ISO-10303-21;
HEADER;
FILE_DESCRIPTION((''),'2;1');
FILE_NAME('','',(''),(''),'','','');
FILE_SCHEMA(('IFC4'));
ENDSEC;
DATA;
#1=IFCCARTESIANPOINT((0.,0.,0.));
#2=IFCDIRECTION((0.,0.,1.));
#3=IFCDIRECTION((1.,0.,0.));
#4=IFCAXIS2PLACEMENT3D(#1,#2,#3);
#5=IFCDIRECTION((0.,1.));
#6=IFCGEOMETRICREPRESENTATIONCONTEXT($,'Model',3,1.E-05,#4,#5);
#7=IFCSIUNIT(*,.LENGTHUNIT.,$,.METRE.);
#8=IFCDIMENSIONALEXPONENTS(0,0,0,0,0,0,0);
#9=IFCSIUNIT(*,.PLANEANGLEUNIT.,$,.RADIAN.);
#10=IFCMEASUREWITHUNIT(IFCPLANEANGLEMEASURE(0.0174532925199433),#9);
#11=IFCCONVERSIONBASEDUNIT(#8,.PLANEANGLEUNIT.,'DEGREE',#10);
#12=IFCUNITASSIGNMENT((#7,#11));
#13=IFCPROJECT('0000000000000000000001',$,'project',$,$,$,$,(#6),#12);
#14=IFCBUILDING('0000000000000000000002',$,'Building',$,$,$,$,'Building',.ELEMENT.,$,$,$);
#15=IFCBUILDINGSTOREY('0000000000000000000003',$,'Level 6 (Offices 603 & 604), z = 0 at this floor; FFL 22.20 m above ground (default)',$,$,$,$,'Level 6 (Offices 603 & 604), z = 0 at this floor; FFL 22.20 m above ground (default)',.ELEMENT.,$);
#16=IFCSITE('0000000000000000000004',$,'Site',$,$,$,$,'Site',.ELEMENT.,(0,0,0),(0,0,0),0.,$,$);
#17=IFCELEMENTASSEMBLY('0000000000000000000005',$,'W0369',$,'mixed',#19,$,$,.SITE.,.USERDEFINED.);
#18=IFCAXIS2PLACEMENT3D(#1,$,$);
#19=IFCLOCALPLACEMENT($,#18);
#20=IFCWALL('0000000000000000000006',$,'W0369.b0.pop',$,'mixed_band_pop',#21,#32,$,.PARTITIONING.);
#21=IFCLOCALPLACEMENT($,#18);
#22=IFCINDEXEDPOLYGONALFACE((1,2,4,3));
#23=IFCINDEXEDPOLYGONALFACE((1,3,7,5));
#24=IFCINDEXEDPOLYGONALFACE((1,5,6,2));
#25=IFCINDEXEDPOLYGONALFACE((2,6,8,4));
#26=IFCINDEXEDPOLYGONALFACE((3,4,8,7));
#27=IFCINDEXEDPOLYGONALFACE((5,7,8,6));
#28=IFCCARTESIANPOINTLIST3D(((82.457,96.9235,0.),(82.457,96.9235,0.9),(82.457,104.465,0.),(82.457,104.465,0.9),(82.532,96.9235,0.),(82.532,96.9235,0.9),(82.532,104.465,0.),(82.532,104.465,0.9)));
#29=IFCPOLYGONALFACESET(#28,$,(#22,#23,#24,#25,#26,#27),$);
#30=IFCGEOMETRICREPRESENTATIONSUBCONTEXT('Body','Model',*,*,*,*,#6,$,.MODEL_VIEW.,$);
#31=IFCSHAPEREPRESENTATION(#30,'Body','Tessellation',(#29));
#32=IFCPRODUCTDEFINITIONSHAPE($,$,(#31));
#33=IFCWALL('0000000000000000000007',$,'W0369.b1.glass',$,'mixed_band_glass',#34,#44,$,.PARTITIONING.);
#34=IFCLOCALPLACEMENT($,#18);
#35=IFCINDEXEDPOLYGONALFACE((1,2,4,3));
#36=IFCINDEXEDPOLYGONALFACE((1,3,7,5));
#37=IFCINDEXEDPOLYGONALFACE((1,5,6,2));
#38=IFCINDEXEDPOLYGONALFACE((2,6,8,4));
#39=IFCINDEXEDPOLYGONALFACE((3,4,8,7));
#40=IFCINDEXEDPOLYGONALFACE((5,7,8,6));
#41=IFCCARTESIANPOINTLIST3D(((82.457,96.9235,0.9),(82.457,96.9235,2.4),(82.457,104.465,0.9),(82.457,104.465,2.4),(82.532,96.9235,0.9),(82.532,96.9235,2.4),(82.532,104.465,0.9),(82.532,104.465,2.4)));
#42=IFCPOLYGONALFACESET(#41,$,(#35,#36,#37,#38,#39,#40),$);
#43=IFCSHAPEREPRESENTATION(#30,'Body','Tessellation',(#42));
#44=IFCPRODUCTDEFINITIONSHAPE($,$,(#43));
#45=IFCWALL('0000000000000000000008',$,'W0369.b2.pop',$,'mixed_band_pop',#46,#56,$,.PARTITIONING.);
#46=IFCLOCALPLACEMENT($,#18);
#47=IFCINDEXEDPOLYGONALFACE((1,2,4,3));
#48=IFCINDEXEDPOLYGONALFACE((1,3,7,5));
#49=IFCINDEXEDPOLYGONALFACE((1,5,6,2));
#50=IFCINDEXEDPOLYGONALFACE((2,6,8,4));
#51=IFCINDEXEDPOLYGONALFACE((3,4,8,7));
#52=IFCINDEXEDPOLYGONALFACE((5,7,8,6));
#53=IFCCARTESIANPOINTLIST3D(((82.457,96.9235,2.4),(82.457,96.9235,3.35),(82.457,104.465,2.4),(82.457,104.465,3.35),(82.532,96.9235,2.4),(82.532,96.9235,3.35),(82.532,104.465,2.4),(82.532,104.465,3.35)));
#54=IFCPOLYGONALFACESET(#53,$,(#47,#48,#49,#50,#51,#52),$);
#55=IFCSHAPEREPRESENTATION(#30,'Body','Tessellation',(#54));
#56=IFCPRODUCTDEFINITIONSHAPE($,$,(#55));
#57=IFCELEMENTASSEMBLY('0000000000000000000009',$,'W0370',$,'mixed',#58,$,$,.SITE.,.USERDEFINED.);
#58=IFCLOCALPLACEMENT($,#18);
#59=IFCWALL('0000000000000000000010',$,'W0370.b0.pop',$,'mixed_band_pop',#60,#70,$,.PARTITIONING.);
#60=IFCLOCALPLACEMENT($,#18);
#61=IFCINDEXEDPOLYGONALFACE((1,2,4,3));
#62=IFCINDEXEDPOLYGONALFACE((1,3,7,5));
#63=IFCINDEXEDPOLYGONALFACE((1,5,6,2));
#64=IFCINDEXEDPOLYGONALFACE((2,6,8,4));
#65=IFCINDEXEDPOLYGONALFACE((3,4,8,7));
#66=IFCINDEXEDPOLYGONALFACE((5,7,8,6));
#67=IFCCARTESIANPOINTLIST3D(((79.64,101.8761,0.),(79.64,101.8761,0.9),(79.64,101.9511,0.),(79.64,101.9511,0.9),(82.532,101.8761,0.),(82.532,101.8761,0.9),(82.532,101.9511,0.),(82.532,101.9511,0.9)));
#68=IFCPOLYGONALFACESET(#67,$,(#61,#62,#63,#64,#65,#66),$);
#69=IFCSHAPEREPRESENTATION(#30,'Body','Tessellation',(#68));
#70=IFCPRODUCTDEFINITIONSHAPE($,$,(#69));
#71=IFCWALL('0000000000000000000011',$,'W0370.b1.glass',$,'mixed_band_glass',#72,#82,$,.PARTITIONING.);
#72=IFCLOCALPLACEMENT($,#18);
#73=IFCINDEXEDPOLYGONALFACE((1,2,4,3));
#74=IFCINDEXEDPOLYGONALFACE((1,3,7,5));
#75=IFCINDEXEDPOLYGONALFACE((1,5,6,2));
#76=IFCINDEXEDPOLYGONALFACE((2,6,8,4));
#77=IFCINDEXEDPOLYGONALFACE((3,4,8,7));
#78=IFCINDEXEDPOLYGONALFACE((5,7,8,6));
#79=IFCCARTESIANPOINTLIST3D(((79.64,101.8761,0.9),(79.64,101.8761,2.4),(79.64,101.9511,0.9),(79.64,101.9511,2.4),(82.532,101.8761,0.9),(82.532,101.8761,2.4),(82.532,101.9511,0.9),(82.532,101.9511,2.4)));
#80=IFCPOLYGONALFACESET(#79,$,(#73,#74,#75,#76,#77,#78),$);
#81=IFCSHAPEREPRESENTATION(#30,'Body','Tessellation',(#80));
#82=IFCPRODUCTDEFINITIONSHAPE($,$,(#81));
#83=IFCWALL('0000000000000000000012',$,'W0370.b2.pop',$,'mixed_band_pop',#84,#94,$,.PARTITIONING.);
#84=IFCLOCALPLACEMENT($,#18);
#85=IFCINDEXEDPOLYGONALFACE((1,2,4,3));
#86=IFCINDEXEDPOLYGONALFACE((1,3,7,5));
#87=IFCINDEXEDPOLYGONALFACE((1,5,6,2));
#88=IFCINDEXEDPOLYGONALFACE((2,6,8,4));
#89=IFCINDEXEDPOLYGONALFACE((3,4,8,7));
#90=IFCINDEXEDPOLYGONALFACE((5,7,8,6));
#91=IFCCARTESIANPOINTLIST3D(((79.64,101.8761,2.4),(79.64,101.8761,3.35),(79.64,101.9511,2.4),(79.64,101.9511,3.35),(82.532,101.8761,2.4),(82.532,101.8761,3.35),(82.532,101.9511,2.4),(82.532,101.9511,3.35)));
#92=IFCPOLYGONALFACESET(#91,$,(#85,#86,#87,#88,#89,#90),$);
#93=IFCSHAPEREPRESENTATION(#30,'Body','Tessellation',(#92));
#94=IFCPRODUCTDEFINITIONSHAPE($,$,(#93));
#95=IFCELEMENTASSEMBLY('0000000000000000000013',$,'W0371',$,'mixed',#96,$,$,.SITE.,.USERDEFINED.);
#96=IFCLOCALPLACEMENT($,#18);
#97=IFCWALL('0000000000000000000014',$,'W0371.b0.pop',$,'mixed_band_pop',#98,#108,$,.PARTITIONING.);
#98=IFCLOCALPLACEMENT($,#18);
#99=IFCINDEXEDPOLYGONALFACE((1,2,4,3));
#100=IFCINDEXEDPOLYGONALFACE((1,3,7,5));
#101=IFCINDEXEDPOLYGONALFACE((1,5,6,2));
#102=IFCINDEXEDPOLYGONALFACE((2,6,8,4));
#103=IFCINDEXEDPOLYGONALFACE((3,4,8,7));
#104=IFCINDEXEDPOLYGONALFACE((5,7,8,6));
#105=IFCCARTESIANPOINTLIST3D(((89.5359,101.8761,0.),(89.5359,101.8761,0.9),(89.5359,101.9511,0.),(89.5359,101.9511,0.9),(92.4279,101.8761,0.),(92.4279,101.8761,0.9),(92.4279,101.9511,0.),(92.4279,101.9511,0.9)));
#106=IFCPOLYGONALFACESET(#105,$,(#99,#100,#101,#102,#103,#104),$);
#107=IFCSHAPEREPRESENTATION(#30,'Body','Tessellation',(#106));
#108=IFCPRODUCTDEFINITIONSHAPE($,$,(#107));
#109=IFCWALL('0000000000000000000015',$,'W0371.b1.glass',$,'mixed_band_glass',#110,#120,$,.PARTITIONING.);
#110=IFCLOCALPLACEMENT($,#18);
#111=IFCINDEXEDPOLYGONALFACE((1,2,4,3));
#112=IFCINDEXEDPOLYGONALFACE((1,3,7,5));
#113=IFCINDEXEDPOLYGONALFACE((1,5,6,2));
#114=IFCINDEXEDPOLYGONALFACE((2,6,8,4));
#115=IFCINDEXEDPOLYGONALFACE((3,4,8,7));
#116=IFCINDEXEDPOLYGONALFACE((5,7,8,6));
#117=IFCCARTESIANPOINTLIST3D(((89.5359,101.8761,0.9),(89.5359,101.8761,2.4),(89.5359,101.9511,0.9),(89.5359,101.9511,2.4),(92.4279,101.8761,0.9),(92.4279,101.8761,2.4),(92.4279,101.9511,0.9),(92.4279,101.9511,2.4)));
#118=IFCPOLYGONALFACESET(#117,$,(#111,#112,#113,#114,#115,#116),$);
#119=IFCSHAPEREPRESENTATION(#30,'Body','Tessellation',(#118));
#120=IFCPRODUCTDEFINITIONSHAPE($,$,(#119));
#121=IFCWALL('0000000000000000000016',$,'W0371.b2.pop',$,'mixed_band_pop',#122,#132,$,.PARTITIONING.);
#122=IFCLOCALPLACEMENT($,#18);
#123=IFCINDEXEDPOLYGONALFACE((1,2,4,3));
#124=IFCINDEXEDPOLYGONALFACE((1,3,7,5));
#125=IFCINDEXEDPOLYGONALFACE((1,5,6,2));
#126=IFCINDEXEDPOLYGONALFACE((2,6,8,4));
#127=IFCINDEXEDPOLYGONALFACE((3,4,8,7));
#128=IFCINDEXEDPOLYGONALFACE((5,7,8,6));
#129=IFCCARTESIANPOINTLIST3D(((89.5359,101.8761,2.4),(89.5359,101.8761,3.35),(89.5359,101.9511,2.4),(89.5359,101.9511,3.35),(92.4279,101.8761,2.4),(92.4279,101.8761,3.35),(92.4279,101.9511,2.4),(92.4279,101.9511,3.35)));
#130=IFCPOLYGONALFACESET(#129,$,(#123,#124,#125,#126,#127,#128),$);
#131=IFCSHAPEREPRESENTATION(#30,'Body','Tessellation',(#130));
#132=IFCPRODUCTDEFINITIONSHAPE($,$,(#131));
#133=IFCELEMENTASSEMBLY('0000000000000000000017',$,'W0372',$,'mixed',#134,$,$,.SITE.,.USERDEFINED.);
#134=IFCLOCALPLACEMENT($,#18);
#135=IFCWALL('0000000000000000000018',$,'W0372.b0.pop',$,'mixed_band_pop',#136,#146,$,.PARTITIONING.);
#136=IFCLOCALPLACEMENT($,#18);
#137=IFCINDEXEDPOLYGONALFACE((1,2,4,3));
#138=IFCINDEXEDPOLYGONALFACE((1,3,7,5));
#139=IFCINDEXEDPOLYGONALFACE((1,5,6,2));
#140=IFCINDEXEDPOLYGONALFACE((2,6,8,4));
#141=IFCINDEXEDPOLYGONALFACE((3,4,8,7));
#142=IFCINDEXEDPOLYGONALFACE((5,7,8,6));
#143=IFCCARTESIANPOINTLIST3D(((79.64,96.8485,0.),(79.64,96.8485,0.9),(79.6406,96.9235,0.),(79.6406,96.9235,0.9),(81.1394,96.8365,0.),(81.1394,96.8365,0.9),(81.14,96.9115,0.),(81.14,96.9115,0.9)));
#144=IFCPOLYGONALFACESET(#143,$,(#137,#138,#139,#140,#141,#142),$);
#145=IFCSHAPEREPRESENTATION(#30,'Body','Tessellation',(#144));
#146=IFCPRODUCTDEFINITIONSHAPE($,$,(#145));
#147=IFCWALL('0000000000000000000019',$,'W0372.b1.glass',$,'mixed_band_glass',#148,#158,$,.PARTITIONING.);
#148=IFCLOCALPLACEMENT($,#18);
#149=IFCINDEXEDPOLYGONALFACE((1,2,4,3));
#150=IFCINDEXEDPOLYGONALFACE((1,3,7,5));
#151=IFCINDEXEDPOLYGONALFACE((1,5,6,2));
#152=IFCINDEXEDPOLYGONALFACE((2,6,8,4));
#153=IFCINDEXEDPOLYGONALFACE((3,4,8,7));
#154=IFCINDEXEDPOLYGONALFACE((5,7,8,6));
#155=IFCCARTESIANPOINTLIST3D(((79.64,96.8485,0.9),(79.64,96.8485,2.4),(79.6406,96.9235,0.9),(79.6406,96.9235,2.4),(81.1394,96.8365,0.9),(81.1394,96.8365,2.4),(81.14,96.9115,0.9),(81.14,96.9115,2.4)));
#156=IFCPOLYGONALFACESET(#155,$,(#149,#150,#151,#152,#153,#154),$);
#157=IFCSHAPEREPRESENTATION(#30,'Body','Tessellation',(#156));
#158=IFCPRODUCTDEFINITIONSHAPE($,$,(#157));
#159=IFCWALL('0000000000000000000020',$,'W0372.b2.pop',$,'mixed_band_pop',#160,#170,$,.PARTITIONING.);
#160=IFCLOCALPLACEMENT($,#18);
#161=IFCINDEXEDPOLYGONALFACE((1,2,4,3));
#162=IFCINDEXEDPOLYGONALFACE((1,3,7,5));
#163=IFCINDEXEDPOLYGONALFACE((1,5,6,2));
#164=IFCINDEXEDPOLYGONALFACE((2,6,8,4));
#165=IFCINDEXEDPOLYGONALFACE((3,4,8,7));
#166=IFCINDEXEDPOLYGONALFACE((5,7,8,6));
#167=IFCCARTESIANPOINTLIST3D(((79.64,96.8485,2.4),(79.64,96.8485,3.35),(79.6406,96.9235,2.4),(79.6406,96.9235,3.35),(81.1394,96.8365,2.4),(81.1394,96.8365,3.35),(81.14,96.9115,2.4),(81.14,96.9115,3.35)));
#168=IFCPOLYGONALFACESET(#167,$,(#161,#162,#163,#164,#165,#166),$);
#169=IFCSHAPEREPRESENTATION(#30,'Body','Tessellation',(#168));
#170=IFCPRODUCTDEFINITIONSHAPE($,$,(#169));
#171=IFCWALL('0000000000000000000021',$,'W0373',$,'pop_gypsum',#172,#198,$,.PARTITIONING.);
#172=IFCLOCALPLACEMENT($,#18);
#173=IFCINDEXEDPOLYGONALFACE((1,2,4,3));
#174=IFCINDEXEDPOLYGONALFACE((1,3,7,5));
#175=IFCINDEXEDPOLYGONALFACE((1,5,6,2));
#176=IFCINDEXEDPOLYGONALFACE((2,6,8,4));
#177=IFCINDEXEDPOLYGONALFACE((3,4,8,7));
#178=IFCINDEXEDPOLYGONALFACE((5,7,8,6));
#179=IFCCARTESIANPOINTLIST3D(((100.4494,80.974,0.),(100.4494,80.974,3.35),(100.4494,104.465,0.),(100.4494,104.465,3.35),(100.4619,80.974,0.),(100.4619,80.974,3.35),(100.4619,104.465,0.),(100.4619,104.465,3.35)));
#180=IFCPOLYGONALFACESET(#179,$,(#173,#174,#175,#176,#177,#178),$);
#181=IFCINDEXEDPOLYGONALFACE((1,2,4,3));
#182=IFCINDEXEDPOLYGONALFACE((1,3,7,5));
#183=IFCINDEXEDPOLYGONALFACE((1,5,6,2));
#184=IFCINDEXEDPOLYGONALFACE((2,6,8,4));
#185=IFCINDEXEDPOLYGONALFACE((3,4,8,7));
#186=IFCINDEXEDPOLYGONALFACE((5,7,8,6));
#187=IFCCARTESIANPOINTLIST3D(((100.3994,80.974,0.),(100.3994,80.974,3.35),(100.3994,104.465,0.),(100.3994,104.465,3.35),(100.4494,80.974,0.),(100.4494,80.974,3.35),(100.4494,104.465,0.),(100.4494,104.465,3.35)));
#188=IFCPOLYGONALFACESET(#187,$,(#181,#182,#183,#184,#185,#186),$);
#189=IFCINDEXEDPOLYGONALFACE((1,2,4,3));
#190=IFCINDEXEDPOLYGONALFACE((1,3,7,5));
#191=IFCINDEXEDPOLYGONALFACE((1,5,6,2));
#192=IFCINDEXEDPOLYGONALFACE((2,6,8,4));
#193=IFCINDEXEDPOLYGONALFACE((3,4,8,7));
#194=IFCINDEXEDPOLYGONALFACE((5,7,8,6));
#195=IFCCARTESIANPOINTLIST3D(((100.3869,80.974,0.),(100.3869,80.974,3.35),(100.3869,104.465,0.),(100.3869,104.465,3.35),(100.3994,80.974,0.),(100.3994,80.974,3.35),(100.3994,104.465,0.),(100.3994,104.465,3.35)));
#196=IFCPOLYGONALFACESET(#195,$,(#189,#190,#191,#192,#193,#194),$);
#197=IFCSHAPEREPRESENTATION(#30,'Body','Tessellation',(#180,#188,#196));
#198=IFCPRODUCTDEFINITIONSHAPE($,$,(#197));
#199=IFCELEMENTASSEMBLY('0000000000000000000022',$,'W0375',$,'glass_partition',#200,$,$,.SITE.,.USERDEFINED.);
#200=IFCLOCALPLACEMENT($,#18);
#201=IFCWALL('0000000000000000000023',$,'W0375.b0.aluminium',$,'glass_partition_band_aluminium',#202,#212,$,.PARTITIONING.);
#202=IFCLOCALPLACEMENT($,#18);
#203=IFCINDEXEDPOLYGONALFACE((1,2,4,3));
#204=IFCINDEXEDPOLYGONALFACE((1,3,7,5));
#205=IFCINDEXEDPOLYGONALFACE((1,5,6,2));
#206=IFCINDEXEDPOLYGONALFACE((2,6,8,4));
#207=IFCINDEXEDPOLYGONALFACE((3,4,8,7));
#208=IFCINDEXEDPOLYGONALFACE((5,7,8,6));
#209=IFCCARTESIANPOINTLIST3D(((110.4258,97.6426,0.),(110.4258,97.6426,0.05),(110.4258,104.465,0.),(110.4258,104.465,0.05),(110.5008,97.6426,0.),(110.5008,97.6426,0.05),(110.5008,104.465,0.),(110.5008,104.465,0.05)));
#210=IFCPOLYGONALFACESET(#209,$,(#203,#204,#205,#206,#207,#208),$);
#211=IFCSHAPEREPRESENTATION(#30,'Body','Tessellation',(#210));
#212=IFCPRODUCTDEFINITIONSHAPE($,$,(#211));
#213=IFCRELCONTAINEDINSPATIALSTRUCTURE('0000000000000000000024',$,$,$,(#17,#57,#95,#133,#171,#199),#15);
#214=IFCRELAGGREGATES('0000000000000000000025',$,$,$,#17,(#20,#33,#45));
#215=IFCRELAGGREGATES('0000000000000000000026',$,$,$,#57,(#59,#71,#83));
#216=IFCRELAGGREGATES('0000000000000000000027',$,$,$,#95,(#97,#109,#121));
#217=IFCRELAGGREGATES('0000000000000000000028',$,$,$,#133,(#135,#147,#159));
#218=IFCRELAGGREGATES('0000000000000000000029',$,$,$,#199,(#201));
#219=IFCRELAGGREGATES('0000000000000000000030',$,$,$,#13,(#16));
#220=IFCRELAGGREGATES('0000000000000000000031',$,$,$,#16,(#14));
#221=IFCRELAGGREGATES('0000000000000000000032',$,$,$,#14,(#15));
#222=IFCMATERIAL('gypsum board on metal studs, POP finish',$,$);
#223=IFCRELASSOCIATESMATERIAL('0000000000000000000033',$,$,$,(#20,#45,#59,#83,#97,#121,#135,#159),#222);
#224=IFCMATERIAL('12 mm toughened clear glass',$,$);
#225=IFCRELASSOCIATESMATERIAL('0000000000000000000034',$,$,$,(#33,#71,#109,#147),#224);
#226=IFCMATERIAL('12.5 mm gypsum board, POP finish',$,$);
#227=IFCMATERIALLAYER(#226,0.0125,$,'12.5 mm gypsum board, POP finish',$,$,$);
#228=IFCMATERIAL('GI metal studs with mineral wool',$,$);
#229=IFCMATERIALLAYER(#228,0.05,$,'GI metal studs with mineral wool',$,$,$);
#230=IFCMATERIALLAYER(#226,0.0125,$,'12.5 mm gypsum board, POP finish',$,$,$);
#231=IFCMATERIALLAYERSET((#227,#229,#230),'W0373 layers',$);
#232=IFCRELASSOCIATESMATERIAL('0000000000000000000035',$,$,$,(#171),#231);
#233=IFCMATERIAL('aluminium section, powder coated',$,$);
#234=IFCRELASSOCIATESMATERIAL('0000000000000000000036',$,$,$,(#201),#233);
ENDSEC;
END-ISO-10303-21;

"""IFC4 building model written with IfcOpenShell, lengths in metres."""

from ifc_helpers import new_model, entity, si_unit, converted_unit, direction, frame, frame_2d, origin_with_axes, place, context, subcontext, project, spatial, rectangle, extrude, material, layer, layer_set, layer_usage, element, aggregate, save


model = new_model("IFC4")

# Units and contexts
model_context = context("Model", 3, precision=1e-05, world=origin_with_axes(), true_north=direction((0.0, 1.0)))
body_context = subcontext(model_context, "Body", "Model", "MODEL_VIEW")
ifc_project = project(units=[si_unit("LENGTHUNIT", "METRE"), converted_unit("PLANEANGLEUNIT", "DEGREE", entity("IfcPlaneAngleMeasure", 0.0174532925199433), si_unit("PLANEANGLEUNIT", "RADIAN"), dimensions=[0, 0, 0, 0, 0, 0, 0])], contexts=[model_context])

# Site, building, storey
site = spatial("IfcSite", under=ifc_project, Name="Site", LongName="Site", CompositionType="ELEMENT", RefLatitude=(0, 0, 0), RefLongitude=(0, 0, 0), RefElevation=0.0)
building = spatial("IfcBuilding", under=site, Name="Building", LongName="Building", CompositionType="ELEMENT")
storey = spatial("IfcBuildingStorey", under=building, Name="Level 6 (Offices 603 & 604), z = 0 at this floor; FFL 22.20 m above ground (default)", LongName="Level 6 (Offices 603 & 604), z = 0 at this floor; FFL 22.20 m above ground (default)", CompositionType="ELEMENT")

# Element assemblies, walls
assembly_1 = element("IfcElementAssembly", 1, inside=storey, Name="W0369", ObjectType="mixed", AssemblyPlace="SITE", PredefinedType="USERDEFINED")
ifc_material_1 = material(Name="gypsum board on metal studs, POP finish")
placement = place(None, origin_with_axes())
wall_1 = element("IfcWall", 2, at=placement, material=ifc_material_1, Name="W0369.b0.pop", ObjectType="mixed_band_pop", PredefinedType="PARTITIONING", context=body_context, shape_type="SweptSolid", body=[
    extrude(rectangle(XDim=7.5415, YDim=0.075, at=frame_2d((0.0, 0.0), x_axis=(0.0, 1.0))), frame((82.4945, 100.6942, 0.0), z_axis=(0.0, 0.0, 1.0), x_axis=(1.0, 0.0, 0.0)), (0.0, 0.0, 1.0), 0.9),
])
ifc_material_2 = material(Name="12 mm toughened clear glass")
wall_2 = element("IfcWall", 3, at=placement, material=ifc_material_2, Name="W0369.b1.glass", ObjectType="mixed_band_glass", PredefinedType="PARTITIONING", context=body_context, shape_type="SweptSolid", body=[
    extrude(rectangle(XDim=7.5415, YDim=0.075, at=frame_2d((0.0, 0.0), x_axis=(0.0, 1.0))), frame((82.4945, 100.6942, 0.9), z_axis=(0.0, 0.0, 1.0), x_axis=(1.0, 0.0, 0.0)), (0.0, 0.0, 1.0), 1.5),
])
wall_3 = element("IfcWall", 4, at=placement, material=ifc_material_1, Name="W0369.b2.pop", ObjectType="mixed_band_pop", PredefinedType="PARTITIONING", context=body_context, shape_type="SweptSolid", body=[
    extrude(rectangle(XDim=7.5415, YDim=0.075, at=frame_2d((0.0, 0.0), x_axis=(0.0, 1.0))), frame((82.4945, 100.6942, 2.4), z_axis=(0.0, 0.0, 1.0), x_axis=(1.0, 0.0, 0.0)), (0.0, 0.0, 1.0), 0.95),
])
aggregate(assembly_1, [wall_1, wall_2, wall_3])
assembly_2 = element("IfcElementAssembly", 5, inside=storey, Name="W0370", ObjectType="mixed", AssemblyPlace="SITE", PredefinedType="USERDEFINED")
wall_4 = element("IfcWall", 6, at=placement, material=ifc_material_1, Name="W0370.b0.pop", ObjectType="mixed_band_pop", PredefinedType="PARTITIONING", context=body_context, shape_type="SweptSolid", body=[
    extrude(rectangle(XDim=2.892, YDim=0.075, at=frame_2d((0.0, 0.0), x_axis=(1.0, 0.0))), frame((81.086, 101.9136, 0.0), z_axis=(0.0, 0.0, 1.0), x_axis=(1.0, 0.0, 0.0)), (0.0, 0.0, 1.0), 0.9),
])
wall_5 = element("IfcWall", 7, at=placement, material=ifc_material_2, Name="W0370.b1.glass", ObjectType="mixed_band_glass", PredefinedType="PARTITIONING", context=body_context, shape_type="SweptSolid", body=[
    extrude(rectangle(XDim=2.892, YDim=0.075, at=frame_2d((0.0, 0.0), x_axis=(1.0, 0.0))), frame((81.086, 101.9136, 0.9), z_axis=(0.0, 0.0, 1.0), x_axis=(1.0, 0.0, 0.0)), (0.0, 0.0, 1.0), 1.5),
])
wall_6 = element("IfcWall", 8, at=placement, material=ifc_material_1, Name="W0370.b2.pop", ObjectType="mixed_band_pop", PredefinedType="PARTITIONING", context=body_context, shape_type="SweptSolid", body=[
    extrude(rectangle(XDim=2.892, YDim=0.075, at=frame_2d((0.0, 0.0), x_axis=(1.0, 0.0))), frame((81.086, 101.9136, 2.4), z_axis=(0.0, 0.0, 1.0), x_axis=(1.0, 0.0, 0.0)), (0.0, 0.0, 1.0), 0.95),
])
aggregate(assembly_2, [wall_4, wall_5, wall_6])
assembly_3 = element("IfcElementAssembly", 9, inside=storey, Name="W0371", ObjectType="mixed", AssemblyPlace="SITE", PredefinedType="USERDEFINED")
wall_7 = element("IfcWall", 10, at=placement, material=ifc_material_1, Name="W0371.b0.pop", ObjectType="mixed_band_pop", PredefinedType="PARTITIONING", context=body_context, shape_type="SweptSolid", body=[
    extrude(rectangle(XDim=2.892, YDim=0.075, at=frame_2d((0.0, 0.0), x_axis=(1.0, 0.0))), frame((90.9819, 101.9136, 0.0), z_axis=(0.0, 0.0, 1.0), x_axis=(1.0, 0.0, 0.0)), (0.0, 0.0, 1.0), 0.9),
])
wall_8 = element("IfcWall", 11, at=placement, material=ifc_material_2, Name="W0371.b1.glass", ObjectType="mixed_band_glass", PredefinedType="PARTITIONING", context=body_context, shape_type="SweptSolid", body=[
    extrude(rectangle(XDim=2.892, YDim=0.075, at=frame_2d((0.0, 0.0), x_axis=(1.0, 0.0))), frame((90.9819, 101.9136, 0.9), z_axis=(0.0, 0.0, 1.0), x_axis=(1.0, 0.0, 0.0)), (0.0, 0.0, 1.0), 1.5),
])
wall_9 = element("IfcWall", 12, at=placement, material=ifc_material_1, Name="W0371.b2.pop", ObjectType="mixed_band_pop", PredefinedType="PARTITIONING", context=body_context, shape_type="SweptSolid", body=[
    extrude(rectangle(XDim=2.892, YDim=0.075, at=frame_2d((0.0, 0.0), x_axis=(1.0, 0.0))), frame((90.9819, 101.9136, 2.4), z_axis=(0.0, 0.0, 1.0), x_axis=(1.0, 0.0, 0.0)), (0.0, 0.0, 1.0), 0.95),
])
aggregate(assembly_3, [wall_7, wall_8, wall_9])
assembly_4 = element("IfcElementAssembly", 13, inside=storey, Name="W0372", ObjectType="mixed", AssemblyPlace="SITE", PredefinedType="USERDEFINED")
wall_10 = element("IfcWall", 14, at=placement, material=ifc_material_1, Name="W0372.b0.pop", ObjectType="mixed_band_pop", PredefinedType="PARTITIONING", context=body_context, shape_type="SweptSolid", body=[
    extrude(rectangle(XDim=1.4994, YDim=0.075, at=frame_2d((0.0, 0.0), x_axis=(0.999968, -0.008003))), frame((80.39, 96.88, 0.0), z_axis=(0.0, 0.0, 1.0), x_axis=(1.0, 0.0, 0.0)), (0.0, 0.0, 1.0), 0.9),
])
wall_11 = element("IfcWall", 15, at=placement, material=ifc_material_2, Name="W0372.b1.glass", ObjectType="mixed_band_glass", PredefinedType="PARTITIONING", context=body_context, shape_type="SweptSolid", body=[
    extrude(rectangle(XDim=1.4994, YDim=0.075, at=frame_2d((0.0, 0.0), x_axis=(0.999968, -0.008003))), frame((80.39, 96.88, 0.9), z_axis=(0.0, 0.0, 1.0), x_axis=(1.0, 0.0, 0.0)), (0.0, 0.0, 1.0), 1.5),
])
wall_12 = element("IfcWall", 16, at=placement, material=ifc_material_1, Name="W0372.b2.pop", ObjectType="mixed_band_pop", PredefinedType="PARTITIONING", context=body_context, shape_type="SweptSolid", body=[
    extrude(rectangle(XDim=1.4994, YDim=0.075, at=frame_2d((0.0, 0.0), x_axis=(0.999968, -0.008003))), frame((80.39, 96.88, 2.4), z_axis=(0.0, 0.0, 1.0), x_axis=(1.0, 0.0, 0.0)), (0.0, 0.0, 1.0), 0.95),
])
aggregate(assembly_4, [wall_10, wall_11, wall_12])

# Wall
ifc_material_3 = material(Name="12.5 mm gypsum board, POP finish")
ifc_layer_1 = layer(ifc_material_3, 0.0125, Name="12.5 mm gypsum board, POP finish")
ifc_material_4 = material(Name="GI metal studs with mineral wool")
ifc_layer_2 = layer(ifc_material_4, 0.05, Name="GI metal studs with mineral wool")
ifc_layer_3 = layer(ifc_material_3, 0.0125, Name="12.5 mm gypsum board, POP finish")
ifc_layer_set = layer_set([ifc_layer_1, ifc_layer_2, ifc_layer_3], Name="W0373 layers")
ifc_layer_usage = layer_usage(ifc_layer_set, "AXIS2", "POSITIVE", -0.0375)
element("IfcWall", 17, at=placement, inside=storey, material=ifc_layer_usage, Name="W0373", ObjectType="pop_gypsum", PredefinedType="PARTITIONING", context=body_context, shape_type="SweptSolid", body=[
    extrude(rectangle(XDim=23.491, YDim=0.0125, at=frame_2d((0.0, 0.0), x_axis=(0.0, 1.0))), frame((100.4557, 92.7195, 0.0), z_axis=(0.0, 0.0, 1.0), x_axis=(1.0, 0.0, 0.0)), (0.0, 0.0, 1.0), 3.35),
    extrude(rectangle(XDim=23.491, YDim=0.05, at=frame_2d((-0.0312, 0.0), x_axis=(0.0, 1.0))), frame((100.4557, 92.7195, 0.0), z_axis=(0.0, 0.0, 1.0), x_axis=(1.0, 0.0, 0.0)), (0.0, 0.0, 1.0), 3.35),
    extrude(rectangle(XDim=23.491, YDim=0.0125, at=frame_2d((-0.0625, 0.0), x_axis=(0.0, 1.0))), frame((100.4557, 92.7195, 0.0), z_axis=(0.0, 0.0, 1.0), x_axis=(1.0, 0.0, 0.0)), (0.0, 0.0, 1.0), 3.35),
])

# Element assembly, wall
assembly_5 = element("IfcElementAssembly", 18, inside=storey, Name="W0375", ObjectType="glass_partition", AssemblyPlace="SITE", PredefinedType="USERDEFINED")
ifc_material_5 = material(Name="aluminium section, powder coated")
wall_13 = element("IfcWall", 19, at=placement, material=ifc_material_5, Name="W0375.b0.aluminium", ObjectType="glass_partition_band_aluminium", PredefinedType="PARTITIONING", context=body_context, shape_type="SweptSolid", body=[
    extrude(rectangle(XDim=6.8224, YDim=0.075, at=frame_2d((0.0, 0.0), x_axis=(0.0, 1.0))), frame((110.4633, 101.0538, 0.0), z_axis=(0.0, 0.0, 1.0), x_axis=(1.0, 0.0, 0.0)), (0.0, 0.0, 1.0), 0.05),
])
aggregate(assembly_5, [wall_13])

save(model, "model.ifc")
